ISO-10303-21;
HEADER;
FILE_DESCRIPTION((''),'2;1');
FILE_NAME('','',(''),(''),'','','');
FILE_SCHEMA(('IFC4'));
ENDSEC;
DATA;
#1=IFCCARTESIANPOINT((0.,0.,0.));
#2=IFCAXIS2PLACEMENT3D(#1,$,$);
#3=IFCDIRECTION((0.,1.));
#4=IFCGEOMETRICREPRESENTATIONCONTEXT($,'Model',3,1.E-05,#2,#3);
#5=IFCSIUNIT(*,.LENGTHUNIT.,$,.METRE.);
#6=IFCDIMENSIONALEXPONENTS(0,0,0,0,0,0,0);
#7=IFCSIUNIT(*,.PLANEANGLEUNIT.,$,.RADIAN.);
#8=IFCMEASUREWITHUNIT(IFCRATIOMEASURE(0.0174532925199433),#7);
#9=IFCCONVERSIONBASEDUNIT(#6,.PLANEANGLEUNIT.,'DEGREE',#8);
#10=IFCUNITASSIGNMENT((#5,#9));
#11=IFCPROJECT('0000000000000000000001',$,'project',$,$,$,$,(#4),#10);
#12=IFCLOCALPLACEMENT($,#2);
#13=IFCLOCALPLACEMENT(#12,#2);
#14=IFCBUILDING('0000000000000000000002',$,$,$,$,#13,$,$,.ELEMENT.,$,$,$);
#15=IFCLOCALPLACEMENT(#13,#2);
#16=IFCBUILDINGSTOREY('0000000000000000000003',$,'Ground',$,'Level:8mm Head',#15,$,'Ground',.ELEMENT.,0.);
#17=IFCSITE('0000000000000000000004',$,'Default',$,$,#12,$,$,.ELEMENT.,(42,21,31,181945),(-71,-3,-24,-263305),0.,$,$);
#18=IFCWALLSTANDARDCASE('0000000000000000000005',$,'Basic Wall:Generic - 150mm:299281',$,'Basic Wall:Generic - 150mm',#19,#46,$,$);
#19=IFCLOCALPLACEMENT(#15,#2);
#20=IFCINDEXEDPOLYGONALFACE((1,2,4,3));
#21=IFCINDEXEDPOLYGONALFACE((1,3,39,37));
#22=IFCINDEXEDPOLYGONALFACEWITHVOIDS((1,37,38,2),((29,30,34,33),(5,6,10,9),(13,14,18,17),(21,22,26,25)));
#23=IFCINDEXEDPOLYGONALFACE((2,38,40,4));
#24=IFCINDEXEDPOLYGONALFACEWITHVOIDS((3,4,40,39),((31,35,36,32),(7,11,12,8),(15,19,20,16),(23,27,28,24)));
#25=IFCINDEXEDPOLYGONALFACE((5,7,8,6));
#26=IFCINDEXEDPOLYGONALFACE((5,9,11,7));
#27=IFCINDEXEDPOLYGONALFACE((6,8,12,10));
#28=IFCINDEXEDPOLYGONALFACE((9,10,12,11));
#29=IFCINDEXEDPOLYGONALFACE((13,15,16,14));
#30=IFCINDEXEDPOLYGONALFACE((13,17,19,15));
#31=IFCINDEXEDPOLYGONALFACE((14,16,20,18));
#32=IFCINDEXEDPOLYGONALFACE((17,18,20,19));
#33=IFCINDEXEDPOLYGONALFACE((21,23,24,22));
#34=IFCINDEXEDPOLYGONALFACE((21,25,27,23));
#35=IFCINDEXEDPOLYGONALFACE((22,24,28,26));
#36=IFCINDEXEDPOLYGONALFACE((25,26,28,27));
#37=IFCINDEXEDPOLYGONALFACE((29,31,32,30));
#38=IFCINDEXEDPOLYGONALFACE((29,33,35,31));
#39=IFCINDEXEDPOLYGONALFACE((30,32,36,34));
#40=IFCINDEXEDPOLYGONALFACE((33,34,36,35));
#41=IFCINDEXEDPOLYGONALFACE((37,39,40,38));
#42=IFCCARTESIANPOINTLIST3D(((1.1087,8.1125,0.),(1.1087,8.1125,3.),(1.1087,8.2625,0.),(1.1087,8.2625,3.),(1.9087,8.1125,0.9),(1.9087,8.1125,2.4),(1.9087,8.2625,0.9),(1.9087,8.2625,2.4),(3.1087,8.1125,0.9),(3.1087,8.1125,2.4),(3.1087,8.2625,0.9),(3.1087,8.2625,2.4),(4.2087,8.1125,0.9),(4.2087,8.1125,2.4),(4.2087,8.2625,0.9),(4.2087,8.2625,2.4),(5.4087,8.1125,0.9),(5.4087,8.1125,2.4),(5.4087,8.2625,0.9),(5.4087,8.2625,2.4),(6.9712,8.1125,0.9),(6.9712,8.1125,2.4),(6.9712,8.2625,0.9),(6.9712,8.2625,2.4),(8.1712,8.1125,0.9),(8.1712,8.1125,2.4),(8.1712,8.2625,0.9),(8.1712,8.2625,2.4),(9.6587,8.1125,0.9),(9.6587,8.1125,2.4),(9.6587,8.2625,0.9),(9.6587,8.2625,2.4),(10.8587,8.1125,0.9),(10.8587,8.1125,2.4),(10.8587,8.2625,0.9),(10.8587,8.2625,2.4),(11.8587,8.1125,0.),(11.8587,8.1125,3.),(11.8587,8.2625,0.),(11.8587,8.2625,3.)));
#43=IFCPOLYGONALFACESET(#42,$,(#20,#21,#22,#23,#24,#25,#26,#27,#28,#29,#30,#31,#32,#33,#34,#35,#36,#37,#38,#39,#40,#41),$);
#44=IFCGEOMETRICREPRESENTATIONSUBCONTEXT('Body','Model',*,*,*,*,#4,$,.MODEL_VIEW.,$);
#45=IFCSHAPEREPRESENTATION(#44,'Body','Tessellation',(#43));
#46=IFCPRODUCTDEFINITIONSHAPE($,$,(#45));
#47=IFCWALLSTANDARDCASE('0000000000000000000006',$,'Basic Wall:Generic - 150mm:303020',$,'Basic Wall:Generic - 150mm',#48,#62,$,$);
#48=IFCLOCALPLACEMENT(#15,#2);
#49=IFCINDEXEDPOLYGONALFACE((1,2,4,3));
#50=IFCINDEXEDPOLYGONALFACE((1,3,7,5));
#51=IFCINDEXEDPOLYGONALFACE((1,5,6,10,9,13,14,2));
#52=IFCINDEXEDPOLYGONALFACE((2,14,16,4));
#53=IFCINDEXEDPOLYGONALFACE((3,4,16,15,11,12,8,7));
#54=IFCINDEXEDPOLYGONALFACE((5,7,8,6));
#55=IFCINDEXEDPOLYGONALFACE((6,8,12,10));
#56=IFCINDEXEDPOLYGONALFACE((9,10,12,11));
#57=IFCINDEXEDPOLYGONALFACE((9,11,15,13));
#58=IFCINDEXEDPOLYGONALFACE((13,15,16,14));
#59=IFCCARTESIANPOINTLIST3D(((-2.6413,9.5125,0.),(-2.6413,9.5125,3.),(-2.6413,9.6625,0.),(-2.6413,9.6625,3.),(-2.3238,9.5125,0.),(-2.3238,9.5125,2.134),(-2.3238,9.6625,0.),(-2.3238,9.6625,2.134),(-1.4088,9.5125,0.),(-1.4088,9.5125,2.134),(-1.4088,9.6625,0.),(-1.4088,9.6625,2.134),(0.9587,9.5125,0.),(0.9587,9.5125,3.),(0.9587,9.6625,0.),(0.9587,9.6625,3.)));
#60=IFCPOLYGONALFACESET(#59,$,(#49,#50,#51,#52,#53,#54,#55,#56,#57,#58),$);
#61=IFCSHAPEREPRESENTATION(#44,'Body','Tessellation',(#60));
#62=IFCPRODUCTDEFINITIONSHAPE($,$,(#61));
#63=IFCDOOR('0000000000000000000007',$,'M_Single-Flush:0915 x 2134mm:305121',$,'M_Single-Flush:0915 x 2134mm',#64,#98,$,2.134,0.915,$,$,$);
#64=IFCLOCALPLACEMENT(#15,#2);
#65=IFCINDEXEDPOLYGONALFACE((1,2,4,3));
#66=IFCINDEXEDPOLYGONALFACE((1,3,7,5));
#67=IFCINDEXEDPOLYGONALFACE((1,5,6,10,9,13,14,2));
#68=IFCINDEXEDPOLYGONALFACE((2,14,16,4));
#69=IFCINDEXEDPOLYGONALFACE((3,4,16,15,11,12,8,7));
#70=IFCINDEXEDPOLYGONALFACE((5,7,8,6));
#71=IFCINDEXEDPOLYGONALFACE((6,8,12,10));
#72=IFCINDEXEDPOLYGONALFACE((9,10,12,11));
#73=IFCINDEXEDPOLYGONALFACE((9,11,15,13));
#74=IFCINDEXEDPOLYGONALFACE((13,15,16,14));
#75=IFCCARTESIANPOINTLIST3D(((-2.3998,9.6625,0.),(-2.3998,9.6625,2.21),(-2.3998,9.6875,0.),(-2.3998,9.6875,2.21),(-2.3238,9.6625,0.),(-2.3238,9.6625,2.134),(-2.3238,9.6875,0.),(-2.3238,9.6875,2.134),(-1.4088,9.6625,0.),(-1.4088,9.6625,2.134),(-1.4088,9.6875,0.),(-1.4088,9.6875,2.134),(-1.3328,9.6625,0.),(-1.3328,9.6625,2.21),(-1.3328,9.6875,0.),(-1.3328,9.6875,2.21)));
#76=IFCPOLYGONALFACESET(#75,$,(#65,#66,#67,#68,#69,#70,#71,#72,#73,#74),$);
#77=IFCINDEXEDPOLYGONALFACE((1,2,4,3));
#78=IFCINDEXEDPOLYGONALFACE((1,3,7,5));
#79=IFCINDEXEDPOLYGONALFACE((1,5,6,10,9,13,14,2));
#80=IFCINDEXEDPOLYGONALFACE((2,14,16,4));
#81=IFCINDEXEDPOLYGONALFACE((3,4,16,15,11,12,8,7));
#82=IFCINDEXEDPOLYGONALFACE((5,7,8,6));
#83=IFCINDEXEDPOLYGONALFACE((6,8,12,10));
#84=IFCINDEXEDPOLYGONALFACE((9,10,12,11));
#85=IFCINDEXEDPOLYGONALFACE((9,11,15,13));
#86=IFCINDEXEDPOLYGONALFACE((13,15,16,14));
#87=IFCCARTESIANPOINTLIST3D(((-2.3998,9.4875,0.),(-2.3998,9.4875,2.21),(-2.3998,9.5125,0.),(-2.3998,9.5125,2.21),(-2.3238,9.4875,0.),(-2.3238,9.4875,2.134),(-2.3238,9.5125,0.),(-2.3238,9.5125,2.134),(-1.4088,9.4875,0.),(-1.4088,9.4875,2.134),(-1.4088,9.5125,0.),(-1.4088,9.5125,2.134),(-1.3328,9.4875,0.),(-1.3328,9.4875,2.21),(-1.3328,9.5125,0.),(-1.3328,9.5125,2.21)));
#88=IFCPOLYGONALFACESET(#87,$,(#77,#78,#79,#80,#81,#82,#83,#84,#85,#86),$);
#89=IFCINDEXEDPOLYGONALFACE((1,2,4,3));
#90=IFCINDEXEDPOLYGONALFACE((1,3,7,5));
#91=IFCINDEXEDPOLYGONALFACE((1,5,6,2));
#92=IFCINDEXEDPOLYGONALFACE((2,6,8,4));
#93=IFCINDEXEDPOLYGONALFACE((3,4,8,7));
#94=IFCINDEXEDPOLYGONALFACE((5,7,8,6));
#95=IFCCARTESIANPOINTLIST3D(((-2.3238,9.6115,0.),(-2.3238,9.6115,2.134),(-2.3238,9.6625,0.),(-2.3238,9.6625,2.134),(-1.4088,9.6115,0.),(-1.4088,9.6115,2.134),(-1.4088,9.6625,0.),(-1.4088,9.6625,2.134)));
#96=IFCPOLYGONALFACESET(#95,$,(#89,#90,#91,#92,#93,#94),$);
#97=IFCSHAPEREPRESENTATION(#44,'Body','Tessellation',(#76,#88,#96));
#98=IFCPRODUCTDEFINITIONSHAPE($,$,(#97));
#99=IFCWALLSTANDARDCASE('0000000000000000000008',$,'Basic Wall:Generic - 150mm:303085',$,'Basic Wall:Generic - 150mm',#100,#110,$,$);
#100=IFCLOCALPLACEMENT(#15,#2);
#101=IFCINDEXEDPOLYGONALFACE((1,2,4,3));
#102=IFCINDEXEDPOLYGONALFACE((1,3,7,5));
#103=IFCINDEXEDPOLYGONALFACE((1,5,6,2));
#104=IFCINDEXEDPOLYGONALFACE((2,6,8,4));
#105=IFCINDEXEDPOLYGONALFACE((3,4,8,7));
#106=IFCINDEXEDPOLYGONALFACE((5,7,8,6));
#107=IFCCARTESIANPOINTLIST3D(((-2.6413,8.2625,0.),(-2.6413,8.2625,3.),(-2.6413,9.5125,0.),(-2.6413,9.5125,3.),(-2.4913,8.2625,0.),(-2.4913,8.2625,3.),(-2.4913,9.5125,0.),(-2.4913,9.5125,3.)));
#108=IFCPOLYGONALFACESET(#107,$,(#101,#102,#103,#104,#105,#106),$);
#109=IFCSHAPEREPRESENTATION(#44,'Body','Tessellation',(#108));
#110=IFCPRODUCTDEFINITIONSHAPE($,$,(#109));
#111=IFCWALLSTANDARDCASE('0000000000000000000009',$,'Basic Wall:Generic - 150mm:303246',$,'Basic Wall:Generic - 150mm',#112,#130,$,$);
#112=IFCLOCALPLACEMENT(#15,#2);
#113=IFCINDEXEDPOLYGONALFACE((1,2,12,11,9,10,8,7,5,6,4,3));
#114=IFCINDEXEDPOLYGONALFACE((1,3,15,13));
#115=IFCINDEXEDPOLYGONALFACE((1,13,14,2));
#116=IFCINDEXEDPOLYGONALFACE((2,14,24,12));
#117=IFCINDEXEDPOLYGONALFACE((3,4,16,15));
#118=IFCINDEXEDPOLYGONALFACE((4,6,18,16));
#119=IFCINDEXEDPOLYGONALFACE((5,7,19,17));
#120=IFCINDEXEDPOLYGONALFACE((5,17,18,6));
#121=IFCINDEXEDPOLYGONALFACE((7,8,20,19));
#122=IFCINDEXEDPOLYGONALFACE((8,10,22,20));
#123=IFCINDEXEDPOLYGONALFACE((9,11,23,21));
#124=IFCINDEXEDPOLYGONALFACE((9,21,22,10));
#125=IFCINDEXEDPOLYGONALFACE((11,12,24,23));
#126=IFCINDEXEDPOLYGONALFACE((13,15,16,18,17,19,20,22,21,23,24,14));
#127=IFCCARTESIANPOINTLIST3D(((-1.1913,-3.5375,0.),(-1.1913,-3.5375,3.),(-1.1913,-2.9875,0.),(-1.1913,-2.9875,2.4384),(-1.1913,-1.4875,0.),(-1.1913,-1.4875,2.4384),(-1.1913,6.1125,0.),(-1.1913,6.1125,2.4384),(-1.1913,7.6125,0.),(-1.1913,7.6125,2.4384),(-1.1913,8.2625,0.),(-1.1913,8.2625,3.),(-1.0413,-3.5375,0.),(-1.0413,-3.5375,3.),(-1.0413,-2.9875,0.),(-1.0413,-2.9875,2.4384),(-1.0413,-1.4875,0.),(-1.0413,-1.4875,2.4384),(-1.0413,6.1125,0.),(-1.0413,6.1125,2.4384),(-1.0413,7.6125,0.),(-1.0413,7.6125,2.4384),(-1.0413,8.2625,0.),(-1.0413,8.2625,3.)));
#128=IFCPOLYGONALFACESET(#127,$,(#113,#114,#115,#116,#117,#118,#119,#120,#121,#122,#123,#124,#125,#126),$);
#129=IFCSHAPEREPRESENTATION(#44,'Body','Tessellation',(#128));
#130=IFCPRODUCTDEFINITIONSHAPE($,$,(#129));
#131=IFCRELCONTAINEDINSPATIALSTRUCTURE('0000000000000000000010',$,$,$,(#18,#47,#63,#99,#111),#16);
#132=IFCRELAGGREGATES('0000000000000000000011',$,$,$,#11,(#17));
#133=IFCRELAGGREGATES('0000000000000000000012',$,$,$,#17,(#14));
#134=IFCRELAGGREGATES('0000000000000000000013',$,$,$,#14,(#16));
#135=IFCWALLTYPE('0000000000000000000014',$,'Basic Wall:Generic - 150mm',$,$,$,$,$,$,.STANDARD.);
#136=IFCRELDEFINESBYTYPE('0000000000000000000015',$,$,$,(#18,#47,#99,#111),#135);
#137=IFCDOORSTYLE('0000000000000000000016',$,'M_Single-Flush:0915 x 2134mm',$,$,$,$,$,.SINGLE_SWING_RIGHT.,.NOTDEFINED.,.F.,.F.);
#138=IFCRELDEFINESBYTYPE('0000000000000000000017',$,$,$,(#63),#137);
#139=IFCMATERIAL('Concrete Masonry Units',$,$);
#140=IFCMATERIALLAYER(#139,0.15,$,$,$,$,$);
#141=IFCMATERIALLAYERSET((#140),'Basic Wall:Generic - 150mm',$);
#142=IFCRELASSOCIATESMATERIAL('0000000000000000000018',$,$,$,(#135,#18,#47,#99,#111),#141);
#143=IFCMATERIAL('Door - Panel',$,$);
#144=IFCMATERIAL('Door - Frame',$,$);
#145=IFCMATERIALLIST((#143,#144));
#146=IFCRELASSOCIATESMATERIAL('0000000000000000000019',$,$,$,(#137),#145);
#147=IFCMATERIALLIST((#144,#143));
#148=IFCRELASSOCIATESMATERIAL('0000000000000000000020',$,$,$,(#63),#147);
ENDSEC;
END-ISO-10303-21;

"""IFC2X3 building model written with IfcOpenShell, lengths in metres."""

from ifc_helpers import new_model, entity, si_unit, converted_unit, direction, frame, frame_2d, origin, origin_2d_with_axis, place, context, subcontext, project, spatial, polyline, rectangle, outline, extrude, source, transform, mapped, material, material_list, layer, layer_set, layer_usage, type_object, type_shapes, element, fill, save


model = new_model("IFC2X3")

# Units and contexts
model_context = context("Model", 3, precision=1e-05, world=origin(), true_north=direction((0.0, 1.0)))
body_context = subcontext(model_context, "Body", "Model", "MODEL_VIEW")
ifc_project = project(units=[si_unit("LENGTHUNIT", "METRE"), converted_unit("PLANEANGLEUNIT", "DEGREE", entity("IfcRatioMeasure", 0.0174532925199433), si_unit("PLANEANGLEUNIT", "RADIAN"), dimensions=[0, 0, 0, 0, 0, 0, 0])], contexts=[model_context])

# Site, building, storey
site_placement = place(None, origin())
site = spatial("IfcSite", under=ifc_project, at=site_placement, Name="Default", CompositionType="ELEMENT", RefLatitude=(42, 21, 31, 181945), RefLongitude=(-71, -3, -24, -263305), RefElevation=0.0)
building_placement = place(site_placement, origin())
building = spatial("IfcBuilding", under=site, at=building_placement, CompositionType="ELEMENT")
storey_placement = place(building_placement, origin())
storey = spatial("IfcBuildingStorey", under=building, at=storey_placement, Name="Ground", ObjectType="Level:8mm Head", LongName="Ground", CompositionType="ELEMENT", Elevation=0.0)

# Shared definitions
ifc_material_1 = material(Name="Concrete Masonry Units")
ifc_layer = layer(ifc_material_1, 0.15)
ifc_layer_set = layer_set([ifc_layer], Name="Basic Wall:Generic - 150mm")
wall_type = type_object("IfcWallType", Name="Basic Wall:Generic - 150mm", PredefinedType="STANDARD", material=ifc_layer_set)

# Shared definitions
ifc_material_2 = material(Name="Door - Frame")
ifc_material_3 = material(Name="Door - Panel")

# Shared definitions
ifc_material_list_1 = material_list([ifc_material_3, ifc_material_2])
door_style_1 = type_object("IfcDoorStyle", Name="M_Single-Flush:0915 x 2134mm", ConstructionType="NOTDEFINED", OperationType="SINGLE_SWING_RIGHT", ParameterTakesPrecedence=False, Sizeable=False, material=ifc_material_list_1)
shared_shape_1 = source(origin(), body_context, "Body", "SweptSolid", [
    extrude(outline(polyline([(-0.5335, -1.124), (0.5335, -1.124), (0.5335, 1.086), (0.4575, 1.086), (0.4575, -1.048), (-0.4575, -1.048), (-0.4575, 1.086), (-0.5335, 1.086), (-0.5335, -1.124)])), frame((0.4575, 0.15, 1.086), z_axis=(0.0, 1.0, 0.0), x_axis=(1.0, 0.0, 0.0)), (0.0, 0.0, 1.0), 0.025),
    extrude(outline(polyline([(-1.124, -0.5335), (1.086, -0.5335), (1.086, -0.4575), (-1.048, -0.4575), (-1.048, 0.4575), (1.086, 0.4575), (1.086, 0.5335), (-1.124, 0.5335), (-1.124, -0.5335)])), frame((0.4575, -0.025, 1.086), z_axis=(0.0, 1.0, 0.0), x_axis=(0.0, 0.0, -1.0)), (0.0, 0.0, 1.0), 0.025),
    extrude(rectangle(XDim=0.051, YDim=0.915, at=frame_2d((0.0, 0.0), x_axis=(1.0, 0.0))), frame((0.4575, 0.1245, 0.0), z_axis=(0.0, 0.0, 1.0), x_axis=(0.0, 1.0, 0.0)), (0.0, 0.0, 1.0), 2.134),
])
type_shapes(door_style_1, [shared_shape_1])

# Wall, openings
ifc_layer_usage_1 = layer_usage(ifc_layer_set, "AXIS2", "POSITIVE", -0.075)
wall_1_placement = place(storey_placement, frame((1.1087, 8.1875, 0.0)))
wall_1 = element("IfcWallStandardCase", 1, at=wall_1_placement, inside=storey, type_object=wall_type, material=ifc_layer_usage_1, Name="Basic Wall:Generic - 150mm:299281", ObjectType="Basic Wall:Generic - 150mm", context=body_context, shape_type="SweptSolid", body=[
    extrude(rectangle(XDim=10.75, YDim=0.15, at=frame_2d((5.375, 0.0), x_axis=(-1.0, 0.0))), origin(), (0.0, 0.0, 1.0), 3.0),
])
opening_1_placement = place(wall_1_placement, frame((2.0, 0.075, 0.9)))
element("IfcOpeningElement", 2, at=opening_1_placement, cuts=wall_1, ObjectType="Opening", context=body_context, shape_type="SweptSolid", body=[
    extrude(rectangle(XDim=1.5, YDim=1.2, at=frame_2d((0.75, 0.6), x_axis=(-1.0, 0.0))), frame((0.0, 0.0, 0.0), z_axis=(0.0, -1.0, 0.0), x_axis=(0.0, 0.0, 1.0)), (0.0, 0.0, 1.0), 0.15),
])
opening_2_placement = place(wall_1_placement, frame((4.3, 0.075, 0.9)))
element("IfcOpeningElement", 3, at=opening_2_placement, cuts=wall_1, ObjectType="Opening", context=body_context, shape_type="SweptSolid", body=[
    extrude(rectangle(XDim=1.5, YDim=1.2, at=frame_2d((0.75, 0.6), x_axis=(-1.0, 0.0))), frame((0.0, 0.0, 0.0), z_axis=(0.0, -1.0, 0.0), x_axis=(0.0, 0.0, 1.0)), (0.0, 0.0, 1.0), 0.15),
])
opening_3_placement = place(wall_1_placement, frame((7.0625, 0.075, 0.9)))
element("IfcOpeningElement", 4, at=opening_3_placement, cuts=wall_1, ObjectType="Opening", context=body_context, shape_type="SweptSolid", body=[
    extrude(rectangle(XDim=1.5, YDim=1.2, at=frame_2d((0.75, 0.6), x_axis=(-1.0, 0.0))), frame((0.0, 0.0, 0.0), z_axis=(0.0, -1.0, 0.0), x_axis=(0.0, 0.0, 1.0)), (0.0, 0.0, 1.0), 0.15),
])
opening_4_placement = place(wall_1_placement, frame((9.75, 0.075, 0.9)))
element("IfcOpeningElement", 5, at=opening_4_placement, cuts=wall_1, ObjectType="Opening", context=body_context, shape_type="SweptSolid", body=[
    extrude(rectangle(XDim=1.5, YDim=1.2, at=frame_2d((0.75, 0.6), x_axis=(-1.0, 0.0))), frame((0.0, 0.0, 0.0), z_axis=(0.0, -1.0, 0.0), x_axis=(0.0, 0.0, 1.0)), (0.0, 0.0, 1.0), 0.15),
])

# Wall, opening, door
ifc_layer_usage_2 = layer_usage(ifc_layer_set, "AXIS2", "NEGATIVE", 0.075)
wall_2_placement = place(storey_placement, frame((0.9587, 9.5875, 0.0), z_axis=(0.0, 0.0, 1.0), x_axis=(-1.0, 0.0, 0.0)))
wall_2 = element("IfcWallStandardCase", 6, at=wall_2_placement, inside=storey, type_object=wall_type, material=ifc_layer_usage_2, Name="Basic Wall:Generic - 150mm:303020", ObjectType="Basic Wall:Generic - 150mm", context=body_context, shape_type="SweptSolid", body=[
    extrude(rectangle(XDim=3.6, YDim=0.15, at=frame_2d((1.8, 0.0), x_axis=(-1.0, 0.0))), origin(), (0.0, 0.0, 1.0), 3.0),
])
opening_5_placement = place(wall_2_placement, frame((3.2825, 0.075, 0.0)))
opening_5 = element("IfcOpeningElement", 7, at=opening_5_placement, cuts=wall_2, ObjectType="Opening", context=body_context, shape_type="SweptSolid", body=[
    extrude(rectangle(XDim=0.915, YDim=2.134, at=frame_2d((1.067, 0.4575), x_axis=(0.0, 1.0))), frame((0.0, 0.0, 0.0), z_axis=(0.0, -1.0, 0.0), x_axis=(0.0, 0.0, 1.0)), (0.0, 0.0, 1.0), 0.15),
])
ifc_material_list_2 = material_list([ifc_material_2, ifc_material_3])
door_1_placement = place(opening_5_placement, frame((0.0, 0.0, 0.0), z_axis=(0.0, 0.0, 1.0), x_axis=(-1.0, 0.0, 0.0)))
door_1 = element("IfcDoor", 8, at=door_1_placement, inside=storey, type_object=door_style_1, material=ifc_material_list_2, Name="M_Single-Flush:0915 x 2134mm:305121", ObjectType="M_Single-Flush:0915 x 2134mm", OverallHeight=2.134, OverallWidth=0.915, context=body_context, shape_type="MappedRepresentation", body=[
    mapped(shared_shape_1, transform((0.0, 0.0, 0.0), scale=1.0)),
])
fill(opening_5, door_1)

# Wall
ifc_layer_usage_3 = layer_usage(ifc_layer_set, "AXIS2", "NEGATIVE", 0.075)
wall_3_placement = place(storey_placement, frame((-2.5663, 9.5125, 0.0), z_axis=(0.0, 0.0, 1.0), x_axis=(0.0, -1.0, 0.0)))
element("IfcWallStandardCase", 9, at=wall_3_placement, inside=storey, type_object=wall_type, material=ifc_layer_usage_3, Name="Basic Wall:Generic - 150mm:303085", ObjectType="Basic Wall:Generic - 150mm", context=body_context, shape_type="SweptSolid", body=[
    extrude(rectangle(XDim=1.25, YDim=0.15, at=frame_2d((0.625, 0.0), x_axis=(-1.0, 0.0))), origin(), (0.0, 0.0, 1.0), 3.0),
])

# Wall, openings
ifc_layer_usage_4 = layer_usage(ifc_layer_set, "AXIS2", "NEGATIVE", 0.075)
wall_4_placement = place(storey_placement, frame((-1.1163, 8.2625, 0.0), z_axis=(0.0, 0.0, 1.0), x_axis=(0.0, -1.0, 0.0)))
wall_4 = element("IfcWallStandardCase", 10, at=wall_4_placement, inside=storey, type_object=wall_type, material=ifc_layer_usage_4, Name="Basic Wall:Generic - 150mm:303246", ObjectType="Basic Wall:Generic - 150mm", context=body_context, shape_type="SweptSolid", body=[
    extrude(rectangle(XDim=11.8, YDim=0.15, at=frame_2d((5.9, 0.0), x_axis=(-1.0, 0.0))), origin(), (0.0, 0.0, 1.0), 3.0),
])
opening_6_placement = place(wall_4_placement, origin())
element("IfcOpeningElement", 11, at=opening_6_placement, cuts=wall_4, ObjectType="Opening", context=body_context, shape_type="SweptSolid", body=[
    extrude(rectangle(XDim=2.4384, YDim=1.5, at=origin_2d_with_axis()), frame((10.5, -0.075, 1.2192), z_axis=(0.0, 1.0, 0.0), x_axis=(0.0, 0.0, -1.0)), (0.0, 0.0, 1.0), 0.15),
])
opening_7_placement = place(wall_4_placement, origin())
element("IfcOpeningElement", 12, at=opening_7_placement, cuts=wall_4, ObjectType="Opening", context=body_context, shape_type="SweptSolid", body=[
    extrude(rectangle(XDim=2.4384, YDim=1.5, at=origin_2d_with_axis()), frame((1.4, -0.075, 1.2192), z_axis=(0.0, 1.0, 0.0), x_axis=(0.0, 0.0, -1.0)), (0.0, 0.0, 1.0), 0.15),
])

save(model, "model.ifc")
